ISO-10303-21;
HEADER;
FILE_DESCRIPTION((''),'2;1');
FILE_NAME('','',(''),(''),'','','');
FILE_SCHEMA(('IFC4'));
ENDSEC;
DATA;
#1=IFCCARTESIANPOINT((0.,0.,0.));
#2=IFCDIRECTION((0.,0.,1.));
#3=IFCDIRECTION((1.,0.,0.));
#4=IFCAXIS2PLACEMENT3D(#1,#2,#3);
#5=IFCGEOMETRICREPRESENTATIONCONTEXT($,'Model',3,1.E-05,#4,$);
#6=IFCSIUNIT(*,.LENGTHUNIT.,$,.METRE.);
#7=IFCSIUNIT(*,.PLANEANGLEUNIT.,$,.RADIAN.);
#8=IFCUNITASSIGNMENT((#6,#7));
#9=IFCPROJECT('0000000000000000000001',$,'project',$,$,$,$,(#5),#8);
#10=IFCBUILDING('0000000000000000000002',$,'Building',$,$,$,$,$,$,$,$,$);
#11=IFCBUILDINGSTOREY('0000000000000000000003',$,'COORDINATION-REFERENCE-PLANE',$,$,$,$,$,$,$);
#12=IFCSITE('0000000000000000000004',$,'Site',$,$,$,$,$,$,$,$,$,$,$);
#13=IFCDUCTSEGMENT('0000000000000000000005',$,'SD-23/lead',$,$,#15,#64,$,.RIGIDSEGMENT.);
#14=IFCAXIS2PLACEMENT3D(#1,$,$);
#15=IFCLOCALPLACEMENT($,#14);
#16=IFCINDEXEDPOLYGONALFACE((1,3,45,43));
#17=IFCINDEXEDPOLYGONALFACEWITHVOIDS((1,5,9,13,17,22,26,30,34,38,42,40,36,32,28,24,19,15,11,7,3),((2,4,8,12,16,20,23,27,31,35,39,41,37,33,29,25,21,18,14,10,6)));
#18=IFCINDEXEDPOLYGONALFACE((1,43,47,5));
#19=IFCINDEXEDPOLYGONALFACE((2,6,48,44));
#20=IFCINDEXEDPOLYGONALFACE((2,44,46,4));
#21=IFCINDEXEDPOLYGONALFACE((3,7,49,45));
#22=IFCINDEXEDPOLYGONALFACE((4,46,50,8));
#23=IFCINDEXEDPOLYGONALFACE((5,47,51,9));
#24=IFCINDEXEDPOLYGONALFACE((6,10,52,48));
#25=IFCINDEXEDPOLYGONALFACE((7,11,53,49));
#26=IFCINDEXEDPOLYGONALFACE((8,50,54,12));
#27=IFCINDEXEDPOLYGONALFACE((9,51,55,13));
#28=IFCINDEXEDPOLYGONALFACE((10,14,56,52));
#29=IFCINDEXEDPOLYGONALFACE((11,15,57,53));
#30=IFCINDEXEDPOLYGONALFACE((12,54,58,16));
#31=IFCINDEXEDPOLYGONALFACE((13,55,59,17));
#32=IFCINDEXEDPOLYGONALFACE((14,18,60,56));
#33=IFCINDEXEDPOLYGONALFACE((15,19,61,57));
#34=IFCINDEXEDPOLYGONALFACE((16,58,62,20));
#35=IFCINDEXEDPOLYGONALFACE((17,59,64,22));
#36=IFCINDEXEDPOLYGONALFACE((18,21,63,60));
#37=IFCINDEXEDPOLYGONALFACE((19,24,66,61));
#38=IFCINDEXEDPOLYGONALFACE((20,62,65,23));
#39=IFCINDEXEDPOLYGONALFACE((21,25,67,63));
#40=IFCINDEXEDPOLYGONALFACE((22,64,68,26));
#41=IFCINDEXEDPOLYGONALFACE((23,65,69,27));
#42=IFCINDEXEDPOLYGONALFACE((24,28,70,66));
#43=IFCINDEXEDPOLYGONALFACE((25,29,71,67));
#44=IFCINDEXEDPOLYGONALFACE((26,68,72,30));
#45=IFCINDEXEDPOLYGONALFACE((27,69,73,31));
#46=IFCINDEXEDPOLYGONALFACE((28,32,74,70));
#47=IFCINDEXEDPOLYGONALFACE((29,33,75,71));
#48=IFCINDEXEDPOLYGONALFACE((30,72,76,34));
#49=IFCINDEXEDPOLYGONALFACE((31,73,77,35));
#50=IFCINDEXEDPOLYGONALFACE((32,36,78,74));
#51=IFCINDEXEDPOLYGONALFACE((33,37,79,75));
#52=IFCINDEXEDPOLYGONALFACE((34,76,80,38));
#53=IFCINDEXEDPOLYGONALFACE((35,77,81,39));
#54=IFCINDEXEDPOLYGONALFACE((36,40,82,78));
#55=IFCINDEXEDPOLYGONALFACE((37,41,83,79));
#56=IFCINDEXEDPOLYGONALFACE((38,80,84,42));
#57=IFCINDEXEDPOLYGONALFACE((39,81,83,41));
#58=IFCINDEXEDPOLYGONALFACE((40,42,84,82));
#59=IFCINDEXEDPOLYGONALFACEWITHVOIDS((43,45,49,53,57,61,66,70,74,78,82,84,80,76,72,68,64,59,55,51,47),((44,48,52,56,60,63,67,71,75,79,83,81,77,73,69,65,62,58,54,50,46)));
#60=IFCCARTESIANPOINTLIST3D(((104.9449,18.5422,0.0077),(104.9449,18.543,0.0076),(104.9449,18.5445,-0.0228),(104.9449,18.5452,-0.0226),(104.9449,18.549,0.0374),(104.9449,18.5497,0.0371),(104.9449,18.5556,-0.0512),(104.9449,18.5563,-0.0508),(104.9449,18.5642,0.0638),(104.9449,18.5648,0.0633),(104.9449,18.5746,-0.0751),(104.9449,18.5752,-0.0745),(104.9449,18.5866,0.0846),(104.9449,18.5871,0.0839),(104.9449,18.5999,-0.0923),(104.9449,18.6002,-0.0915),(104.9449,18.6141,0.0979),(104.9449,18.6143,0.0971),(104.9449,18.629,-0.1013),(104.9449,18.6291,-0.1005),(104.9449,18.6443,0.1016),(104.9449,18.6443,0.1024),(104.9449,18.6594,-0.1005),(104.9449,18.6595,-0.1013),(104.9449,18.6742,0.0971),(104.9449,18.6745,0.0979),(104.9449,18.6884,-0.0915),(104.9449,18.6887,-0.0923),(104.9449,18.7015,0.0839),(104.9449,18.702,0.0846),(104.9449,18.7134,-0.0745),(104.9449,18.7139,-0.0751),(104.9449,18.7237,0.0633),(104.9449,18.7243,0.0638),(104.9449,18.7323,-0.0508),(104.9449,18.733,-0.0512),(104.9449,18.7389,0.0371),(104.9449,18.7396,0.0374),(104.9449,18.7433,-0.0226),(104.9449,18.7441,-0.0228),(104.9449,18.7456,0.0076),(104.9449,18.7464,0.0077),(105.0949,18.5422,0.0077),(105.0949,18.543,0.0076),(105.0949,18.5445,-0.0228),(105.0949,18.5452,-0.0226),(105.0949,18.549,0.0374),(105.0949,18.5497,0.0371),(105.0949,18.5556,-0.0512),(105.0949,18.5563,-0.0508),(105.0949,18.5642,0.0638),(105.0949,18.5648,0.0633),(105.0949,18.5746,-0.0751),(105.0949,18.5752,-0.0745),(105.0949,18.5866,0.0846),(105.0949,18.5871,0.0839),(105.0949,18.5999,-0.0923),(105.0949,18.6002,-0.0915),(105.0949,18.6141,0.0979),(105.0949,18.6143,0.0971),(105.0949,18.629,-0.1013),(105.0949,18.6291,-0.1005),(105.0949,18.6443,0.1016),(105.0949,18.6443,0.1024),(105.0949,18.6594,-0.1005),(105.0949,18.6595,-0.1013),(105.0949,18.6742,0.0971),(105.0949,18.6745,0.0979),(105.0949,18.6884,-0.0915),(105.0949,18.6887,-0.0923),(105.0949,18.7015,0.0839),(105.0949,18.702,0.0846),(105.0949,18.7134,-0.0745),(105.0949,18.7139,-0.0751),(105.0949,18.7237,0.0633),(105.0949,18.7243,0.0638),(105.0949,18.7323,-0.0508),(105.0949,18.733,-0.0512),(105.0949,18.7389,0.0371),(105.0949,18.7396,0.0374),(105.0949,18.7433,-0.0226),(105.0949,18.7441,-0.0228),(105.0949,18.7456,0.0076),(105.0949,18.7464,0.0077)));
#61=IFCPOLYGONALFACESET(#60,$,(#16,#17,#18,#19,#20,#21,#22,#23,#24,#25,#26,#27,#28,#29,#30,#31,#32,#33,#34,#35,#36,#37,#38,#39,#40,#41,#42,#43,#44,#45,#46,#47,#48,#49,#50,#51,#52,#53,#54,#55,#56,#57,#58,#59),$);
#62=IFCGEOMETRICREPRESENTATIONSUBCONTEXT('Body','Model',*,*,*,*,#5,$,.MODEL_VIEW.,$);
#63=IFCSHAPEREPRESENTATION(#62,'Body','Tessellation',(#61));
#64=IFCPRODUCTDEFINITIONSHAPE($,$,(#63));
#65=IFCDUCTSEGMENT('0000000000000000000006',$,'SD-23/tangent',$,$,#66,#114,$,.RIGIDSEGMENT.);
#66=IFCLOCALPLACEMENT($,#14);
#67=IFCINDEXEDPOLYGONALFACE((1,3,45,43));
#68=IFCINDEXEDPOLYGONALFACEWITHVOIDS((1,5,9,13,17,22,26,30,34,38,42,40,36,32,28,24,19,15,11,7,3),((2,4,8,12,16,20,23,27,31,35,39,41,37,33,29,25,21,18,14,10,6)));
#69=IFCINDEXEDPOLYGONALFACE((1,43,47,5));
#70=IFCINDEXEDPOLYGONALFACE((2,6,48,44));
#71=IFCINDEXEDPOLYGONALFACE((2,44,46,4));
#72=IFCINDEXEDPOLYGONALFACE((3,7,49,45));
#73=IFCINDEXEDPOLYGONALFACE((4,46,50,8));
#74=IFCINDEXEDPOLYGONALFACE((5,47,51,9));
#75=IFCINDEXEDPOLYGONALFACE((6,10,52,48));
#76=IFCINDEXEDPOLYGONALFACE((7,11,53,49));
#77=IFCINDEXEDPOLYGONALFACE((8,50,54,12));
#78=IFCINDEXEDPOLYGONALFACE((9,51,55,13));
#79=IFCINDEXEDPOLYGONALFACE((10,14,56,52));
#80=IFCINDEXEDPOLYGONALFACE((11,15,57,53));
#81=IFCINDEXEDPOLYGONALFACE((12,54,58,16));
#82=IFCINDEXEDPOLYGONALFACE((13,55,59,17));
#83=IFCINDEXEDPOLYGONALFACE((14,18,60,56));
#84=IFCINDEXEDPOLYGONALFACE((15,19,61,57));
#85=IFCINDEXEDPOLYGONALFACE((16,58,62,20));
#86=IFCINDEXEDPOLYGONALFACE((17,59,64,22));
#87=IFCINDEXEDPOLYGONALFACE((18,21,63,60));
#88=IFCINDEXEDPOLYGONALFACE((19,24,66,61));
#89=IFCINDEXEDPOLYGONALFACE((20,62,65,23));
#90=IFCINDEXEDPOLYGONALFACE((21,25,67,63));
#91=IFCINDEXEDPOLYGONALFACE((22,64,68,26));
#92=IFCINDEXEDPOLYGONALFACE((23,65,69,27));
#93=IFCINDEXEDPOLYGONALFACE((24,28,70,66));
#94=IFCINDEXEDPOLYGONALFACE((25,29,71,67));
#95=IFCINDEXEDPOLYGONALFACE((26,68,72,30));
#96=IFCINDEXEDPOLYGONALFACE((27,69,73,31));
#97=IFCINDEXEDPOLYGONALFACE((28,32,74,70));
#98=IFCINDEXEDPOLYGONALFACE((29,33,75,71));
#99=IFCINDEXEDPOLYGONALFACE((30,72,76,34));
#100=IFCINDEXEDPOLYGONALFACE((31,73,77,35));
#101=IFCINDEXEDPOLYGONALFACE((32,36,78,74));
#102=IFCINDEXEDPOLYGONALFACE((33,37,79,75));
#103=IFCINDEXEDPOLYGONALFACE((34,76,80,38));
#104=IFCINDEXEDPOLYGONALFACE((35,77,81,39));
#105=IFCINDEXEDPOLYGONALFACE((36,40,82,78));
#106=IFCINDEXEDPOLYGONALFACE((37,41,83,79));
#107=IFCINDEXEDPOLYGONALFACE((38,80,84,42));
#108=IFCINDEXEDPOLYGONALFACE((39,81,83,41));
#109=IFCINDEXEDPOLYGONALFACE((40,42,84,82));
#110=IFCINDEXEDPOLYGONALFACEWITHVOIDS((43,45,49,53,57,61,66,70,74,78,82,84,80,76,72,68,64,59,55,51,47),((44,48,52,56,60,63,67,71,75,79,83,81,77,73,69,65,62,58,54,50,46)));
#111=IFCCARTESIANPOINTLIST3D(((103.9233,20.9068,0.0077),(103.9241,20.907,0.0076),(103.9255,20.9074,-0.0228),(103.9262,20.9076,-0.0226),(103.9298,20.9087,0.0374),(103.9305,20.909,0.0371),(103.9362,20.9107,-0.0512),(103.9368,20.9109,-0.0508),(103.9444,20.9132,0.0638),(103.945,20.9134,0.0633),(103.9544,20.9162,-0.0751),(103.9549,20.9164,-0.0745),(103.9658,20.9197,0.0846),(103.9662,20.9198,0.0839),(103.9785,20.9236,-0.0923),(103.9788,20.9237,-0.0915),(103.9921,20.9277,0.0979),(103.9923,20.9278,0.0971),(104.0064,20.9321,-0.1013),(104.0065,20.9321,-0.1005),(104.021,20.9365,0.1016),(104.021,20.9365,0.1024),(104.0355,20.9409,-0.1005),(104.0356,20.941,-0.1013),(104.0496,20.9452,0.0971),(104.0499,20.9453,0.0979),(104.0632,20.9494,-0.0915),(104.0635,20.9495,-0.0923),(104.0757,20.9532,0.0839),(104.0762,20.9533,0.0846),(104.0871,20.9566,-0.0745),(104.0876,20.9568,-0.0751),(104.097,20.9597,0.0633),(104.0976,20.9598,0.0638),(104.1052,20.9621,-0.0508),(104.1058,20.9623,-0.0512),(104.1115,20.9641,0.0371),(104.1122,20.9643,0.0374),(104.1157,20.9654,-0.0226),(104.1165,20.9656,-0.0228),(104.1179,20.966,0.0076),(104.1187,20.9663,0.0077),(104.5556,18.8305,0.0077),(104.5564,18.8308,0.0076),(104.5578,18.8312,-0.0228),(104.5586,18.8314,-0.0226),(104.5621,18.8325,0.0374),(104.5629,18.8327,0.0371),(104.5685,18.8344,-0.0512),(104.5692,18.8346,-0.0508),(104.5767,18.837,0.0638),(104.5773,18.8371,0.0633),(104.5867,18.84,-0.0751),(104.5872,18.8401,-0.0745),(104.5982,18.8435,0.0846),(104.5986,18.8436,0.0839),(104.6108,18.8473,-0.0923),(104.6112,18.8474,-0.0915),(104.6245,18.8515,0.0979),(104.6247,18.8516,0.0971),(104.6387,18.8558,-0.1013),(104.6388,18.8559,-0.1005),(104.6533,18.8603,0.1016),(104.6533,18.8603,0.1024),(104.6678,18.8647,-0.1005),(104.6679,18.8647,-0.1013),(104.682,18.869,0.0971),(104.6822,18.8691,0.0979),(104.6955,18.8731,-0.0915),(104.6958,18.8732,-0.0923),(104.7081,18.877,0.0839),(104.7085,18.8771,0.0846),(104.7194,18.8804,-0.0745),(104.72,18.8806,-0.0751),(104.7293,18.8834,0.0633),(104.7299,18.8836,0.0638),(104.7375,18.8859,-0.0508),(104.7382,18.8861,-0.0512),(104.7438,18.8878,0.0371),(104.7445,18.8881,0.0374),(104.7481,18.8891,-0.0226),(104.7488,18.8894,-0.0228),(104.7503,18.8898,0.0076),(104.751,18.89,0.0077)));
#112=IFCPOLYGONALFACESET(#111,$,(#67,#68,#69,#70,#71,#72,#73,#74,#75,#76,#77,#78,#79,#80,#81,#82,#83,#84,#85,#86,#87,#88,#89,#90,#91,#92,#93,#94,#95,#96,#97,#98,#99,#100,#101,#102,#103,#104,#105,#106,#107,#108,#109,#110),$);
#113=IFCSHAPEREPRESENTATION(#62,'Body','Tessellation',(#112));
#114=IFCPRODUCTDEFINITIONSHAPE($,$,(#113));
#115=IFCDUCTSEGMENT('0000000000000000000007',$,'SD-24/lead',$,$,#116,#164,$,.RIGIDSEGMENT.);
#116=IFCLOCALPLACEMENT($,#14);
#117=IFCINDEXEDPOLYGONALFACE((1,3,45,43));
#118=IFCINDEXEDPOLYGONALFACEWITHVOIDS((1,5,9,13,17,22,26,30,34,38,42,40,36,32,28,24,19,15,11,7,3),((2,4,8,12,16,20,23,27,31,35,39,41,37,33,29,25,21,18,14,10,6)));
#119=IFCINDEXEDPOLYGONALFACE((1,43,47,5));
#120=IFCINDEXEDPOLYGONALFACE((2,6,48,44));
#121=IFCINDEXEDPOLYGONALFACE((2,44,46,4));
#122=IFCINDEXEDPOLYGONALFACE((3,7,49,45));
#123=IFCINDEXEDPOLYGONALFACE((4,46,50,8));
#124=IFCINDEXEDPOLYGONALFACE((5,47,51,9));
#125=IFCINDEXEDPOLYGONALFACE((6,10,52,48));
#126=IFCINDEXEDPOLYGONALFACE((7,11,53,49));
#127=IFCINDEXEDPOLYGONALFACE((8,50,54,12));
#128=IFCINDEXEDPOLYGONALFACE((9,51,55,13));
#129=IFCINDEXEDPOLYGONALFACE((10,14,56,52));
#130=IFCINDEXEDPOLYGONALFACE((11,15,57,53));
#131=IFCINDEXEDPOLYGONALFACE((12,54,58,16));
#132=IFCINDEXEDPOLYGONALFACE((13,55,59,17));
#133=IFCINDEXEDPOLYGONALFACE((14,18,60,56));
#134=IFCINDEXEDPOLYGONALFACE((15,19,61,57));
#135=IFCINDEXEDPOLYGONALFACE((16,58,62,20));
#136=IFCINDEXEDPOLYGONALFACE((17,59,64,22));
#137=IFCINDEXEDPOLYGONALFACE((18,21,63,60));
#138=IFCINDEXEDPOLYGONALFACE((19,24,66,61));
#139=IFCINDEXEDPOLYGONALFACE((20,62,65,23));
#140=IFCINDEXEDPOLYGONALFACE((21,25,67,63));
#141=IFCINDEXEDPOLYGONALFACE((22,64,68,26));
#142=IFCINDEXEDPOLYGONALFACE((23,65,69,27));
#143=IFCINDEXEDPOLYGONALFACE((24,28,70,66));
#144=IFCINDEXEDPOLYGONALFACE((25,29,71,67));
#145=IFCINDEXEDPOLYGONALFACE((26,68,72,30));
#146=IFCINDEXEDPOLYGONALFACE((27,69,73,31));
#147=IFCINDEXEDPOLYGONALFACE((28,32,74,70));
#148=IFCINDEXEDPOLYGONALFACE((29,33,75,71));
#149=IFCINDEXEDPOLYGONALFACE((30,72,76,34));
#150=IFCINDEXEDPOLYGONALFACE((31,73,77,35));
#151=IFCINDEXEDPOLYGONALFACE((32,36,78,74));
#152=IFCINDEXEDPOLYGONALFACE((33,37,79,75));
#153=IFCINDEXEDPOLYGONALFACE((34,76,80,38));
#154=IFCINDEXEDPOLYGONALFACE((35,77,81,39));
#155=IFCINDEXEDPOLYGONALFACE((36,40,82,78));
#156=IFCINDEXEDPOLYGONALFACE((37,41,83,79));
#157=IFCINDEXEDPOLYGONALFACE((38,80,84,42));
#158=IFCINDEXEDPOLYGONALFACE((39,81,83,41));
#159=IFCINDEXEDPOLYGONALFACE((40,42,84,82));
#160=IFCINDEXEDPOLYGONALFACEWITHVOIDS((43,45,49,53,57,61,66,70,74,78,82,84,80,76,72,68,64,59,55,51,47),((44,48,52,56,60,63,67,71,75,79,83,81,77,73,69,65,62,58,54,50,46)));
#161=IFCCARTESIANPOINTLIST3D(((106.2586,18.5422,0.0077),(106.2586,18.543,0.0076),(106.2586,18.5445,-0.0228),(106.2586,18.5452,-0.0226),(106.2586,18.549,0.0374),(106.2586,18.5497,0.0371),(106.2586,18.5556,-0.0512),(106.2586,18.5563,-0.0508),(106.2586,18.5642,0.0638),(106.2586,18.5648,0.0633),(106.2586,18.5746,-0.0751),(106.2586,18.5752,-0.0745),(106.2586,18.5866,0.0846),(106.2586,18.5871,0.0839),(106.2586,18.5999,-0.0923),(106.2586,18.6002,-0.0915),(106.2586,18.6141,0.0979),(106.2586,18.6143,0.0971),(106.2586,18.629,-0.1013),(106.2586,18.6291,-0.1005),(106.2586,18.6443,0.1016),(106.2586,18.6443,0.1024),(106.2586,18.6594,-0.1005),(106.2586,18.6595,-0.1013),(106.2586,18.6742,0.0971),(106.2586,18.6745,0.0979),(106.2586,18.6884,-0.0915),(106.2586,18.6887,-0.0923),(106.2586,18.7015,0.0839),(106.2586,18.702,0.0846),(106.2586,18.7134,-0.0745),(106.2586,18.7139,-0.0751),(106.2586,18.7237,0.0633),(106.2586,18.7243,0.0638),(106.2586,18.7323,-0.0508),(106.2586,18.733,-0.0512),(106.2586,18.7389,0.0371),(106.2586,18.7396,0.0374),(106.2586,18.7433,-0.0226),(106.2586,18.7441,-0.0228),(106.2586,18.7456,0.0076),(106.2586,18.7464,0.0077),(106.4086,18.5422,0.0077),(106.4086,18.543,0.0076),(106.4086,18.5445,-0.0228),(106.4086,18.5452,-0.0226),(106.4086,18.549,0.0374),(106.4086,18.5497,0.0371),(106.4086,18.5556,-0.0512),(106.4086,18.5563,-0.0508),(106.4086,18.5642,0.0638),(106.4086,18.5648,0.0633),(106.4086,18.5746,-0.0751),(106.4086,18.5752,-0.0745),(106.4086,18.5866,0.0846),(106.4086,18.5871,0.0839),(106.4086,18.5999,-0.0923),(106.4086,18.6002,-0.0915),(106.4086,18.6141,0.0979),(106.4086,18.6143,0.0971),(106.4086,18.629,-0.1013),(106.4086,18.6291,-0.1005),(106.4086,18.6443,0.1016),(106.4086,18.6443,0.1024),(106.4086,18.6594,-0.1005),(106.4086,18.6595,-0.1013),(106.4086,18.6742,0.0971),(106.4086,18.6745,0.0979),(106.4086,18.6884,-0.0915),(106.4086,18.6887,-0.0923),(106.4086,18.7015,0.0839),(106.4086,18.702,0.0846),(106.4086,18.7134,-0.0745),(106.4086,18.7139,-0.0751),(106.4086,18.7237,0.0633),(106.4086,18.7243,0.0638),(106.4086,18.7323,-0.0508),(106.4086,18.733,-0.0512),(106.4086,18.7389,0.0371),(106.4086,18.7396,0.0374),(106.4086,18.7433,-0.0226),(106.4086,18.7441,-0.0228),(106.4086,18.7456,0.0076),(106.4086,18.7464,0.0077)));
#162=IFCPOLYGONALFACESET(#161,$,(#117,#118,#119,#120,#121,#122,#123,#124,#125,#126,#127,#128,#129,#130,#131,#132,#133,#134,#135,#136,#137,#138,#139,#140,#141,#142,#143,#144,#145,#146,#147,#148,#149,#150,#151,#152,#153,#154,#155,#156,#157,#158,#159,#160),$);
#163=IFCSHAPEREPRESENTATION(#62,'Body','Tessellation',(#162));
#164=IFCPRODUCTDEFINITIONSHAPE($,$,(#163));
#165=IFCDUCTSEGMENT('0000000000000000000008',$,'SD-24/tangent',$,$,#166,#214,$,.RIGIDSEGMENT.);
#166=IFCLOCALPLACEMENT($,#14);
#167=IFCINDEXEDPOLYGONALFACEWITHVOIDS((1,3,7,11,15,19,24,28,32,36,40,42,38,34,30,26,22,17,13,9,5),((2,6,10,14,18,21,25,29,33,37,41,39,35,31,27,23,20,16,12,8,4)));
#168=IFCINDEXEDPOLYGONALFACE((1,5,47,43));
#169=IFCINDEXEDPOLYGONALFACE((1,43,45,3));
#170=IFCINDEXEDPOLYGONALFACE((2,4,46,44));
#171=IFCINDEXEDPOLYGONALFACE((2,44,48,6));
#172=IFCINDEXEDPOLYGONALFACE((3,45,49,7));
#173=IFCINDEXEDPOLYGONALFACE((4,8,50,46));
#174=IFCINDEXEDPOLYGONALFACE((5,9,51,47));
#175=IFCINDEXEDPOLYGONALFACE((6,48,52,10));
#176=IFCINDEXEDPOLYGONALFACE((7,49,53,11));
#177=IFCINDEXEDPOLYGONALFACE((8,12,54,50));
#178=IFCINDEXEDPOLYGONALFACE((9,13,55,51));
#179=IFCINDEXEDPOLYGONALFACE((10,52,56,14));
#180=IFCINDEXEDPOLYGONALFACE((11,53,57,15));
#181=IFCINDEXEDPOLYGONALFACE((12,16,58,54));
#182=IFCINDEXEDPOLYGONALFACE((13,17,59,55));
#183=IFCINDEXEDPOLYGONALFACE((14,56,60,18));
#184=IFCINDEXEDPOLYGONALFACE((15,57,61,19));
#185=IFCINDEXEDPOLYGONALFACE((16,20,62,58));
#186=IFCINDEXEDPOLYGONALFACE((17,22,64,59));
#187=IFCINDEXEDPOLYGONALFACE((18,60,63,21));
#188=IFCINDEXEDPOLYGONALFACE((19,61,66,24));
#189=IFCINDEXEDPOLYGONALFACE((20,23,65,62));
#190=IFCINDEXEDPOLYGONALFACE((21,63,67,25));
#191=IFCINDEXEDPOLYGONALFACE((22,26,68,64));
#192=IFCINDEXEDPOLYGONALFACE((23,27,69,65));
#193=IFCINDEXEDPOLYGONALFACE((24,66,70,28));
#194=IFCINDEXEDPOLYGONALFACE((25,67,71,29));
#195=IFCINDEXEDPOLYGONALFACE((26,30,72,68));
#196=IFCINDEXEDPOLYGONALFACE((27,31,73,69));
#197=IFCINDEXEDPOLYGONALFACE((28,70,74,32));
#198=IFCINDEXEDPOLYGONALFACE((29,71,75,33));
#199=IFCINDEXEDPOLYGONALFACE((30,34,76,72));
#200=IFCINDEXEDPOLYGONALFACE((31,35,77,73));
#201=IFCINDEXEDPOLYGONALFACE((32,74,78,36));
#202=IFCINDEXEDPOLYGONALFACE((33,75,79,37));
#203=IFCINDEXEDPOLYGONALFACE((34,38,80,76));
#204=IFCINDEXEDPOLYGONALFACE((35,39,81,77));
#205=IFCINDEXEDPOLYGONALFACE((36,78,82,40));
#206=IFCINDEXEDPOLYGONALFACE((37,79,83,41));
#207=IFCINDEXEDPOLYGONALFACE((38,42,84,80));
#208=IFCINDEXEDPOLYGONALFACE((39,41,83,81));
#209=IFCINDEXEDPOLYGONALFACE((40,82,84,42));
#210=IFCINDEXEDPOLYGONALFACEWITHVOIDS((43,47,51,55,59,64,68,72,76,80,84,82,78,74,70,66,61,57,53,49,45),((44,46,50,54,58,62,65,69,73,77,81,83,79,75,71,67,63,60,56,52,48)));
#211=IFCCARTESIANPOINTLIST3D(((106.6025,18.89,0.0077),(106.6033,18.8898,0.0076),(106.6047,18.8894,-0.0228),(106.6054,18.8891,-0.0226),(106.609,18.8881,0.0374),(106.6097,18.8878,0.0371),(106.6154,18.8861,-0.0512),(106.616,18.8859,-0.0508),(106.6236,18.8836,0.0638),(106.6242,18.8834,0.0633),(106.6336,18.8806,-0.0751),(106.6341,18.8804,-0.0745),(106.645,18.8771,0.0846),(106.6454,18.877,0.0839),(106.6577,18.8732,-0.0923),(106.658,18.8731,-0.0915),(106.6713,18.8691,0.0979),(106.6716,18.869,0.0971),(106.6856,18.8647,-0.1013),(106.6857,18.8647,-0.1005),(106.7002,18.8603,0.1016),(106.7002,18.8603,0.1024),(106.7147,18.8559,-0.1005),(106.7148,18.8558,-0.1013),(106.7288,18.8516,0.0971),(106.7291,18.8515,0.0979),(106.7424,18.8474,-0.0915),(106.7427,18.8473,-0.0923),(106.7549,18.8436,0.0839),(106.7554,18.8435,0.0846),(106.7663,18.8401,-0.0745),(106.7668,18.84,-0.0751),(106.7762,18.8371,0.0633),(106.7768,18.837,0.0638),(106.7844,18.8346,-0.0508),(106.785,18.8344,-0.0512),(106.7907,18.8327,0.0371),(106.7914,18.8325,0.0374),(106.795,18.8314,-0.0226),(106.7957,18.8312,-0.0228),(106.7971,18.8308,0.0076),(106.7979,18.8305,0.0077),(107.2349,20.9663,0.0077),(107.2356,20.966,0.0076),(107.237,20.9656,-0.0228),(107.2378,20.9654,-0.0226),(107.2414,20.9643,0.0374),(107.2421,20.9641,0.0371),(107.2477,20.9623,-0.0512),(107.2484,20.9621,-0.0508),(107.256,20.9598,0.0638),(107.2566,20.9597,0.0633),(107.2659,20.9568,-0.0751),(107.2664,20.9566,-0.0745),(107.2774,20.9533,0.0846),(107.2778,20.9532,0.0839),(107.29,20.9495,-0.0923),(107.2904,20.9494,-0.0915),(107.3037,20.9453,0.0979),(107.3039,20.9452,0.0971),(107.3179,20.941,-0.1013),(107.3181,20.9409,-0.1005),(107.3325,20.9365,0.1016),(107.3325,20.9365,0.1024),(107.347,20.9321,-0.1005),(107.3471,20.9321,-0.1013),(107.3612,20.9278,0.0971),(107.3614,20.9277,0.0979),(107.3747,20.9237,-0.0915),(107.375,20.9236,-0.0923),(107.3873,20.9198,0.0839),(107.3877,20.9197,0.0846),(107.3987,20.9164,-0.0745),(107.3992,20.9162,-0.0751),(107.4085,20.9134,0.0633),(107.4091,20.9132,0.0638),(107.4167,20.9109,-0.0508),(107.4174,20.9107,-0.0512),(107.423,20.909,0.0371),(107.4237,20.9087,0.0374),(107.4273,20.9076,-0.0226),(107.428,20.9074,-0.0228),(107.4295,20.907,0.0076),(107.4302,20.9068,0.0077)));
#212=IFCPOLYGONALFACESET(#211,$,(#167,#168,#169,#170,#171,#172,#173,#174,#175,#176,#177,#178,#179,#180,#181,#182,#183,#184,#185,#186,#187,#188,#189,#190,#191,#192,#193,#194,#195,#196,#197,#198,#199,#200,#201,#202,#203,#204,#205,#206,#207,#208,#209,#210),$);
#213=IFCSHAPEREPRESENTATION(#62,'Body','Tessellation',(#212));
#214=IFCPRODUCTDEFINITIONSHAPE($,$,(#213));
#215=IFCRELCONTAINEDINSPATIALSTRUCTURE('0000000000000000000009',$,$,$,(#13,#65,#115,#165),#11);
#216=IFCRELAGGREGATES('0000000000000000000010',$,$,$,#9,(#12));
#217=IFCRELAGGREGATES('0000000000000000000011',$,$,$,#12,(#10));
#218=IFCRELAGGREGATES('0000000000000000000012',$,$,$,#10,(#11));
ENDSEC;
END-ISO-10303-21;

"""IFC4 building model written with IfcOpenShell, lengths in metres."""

from ifc_helpers import new_model, si_unit, frame, origin_with_axes, place, context, subcontext, project, spatial, hollow_circle, extrude, element, save


model = new_model("IFC4")

# Units and contexts
model_context_1 = context("Model", 3, precision=1e-05, world=origin_with_axes())
body_context_1 = subcontext(model_context_1, "Body", "Model", "MODEL_VIEW")
ifc_project = project(units=[si_unit("LENGTHUNIT", "METRE"), si_unit("PLANEANGLEUNIT", "RADIAN")], contexts=[model_context_1])

# Site, building, storey
site = spatial("IfcSite", under=ifc_project, Name="Site")
building = spatial("IfcBuilding", under=site, Name="Building")
storey = spatial("IfcBuildingStorey", under=building, Name="COORDINATION-REFERENCE-PLANE")

# Duct segment
duct_segment_1_placement = place(None, frame((105.0949, 18.6443, 0.0), z_axis=(-1.0, 0.0, 0.0), x_axis=(0.0, 0.0, 1.0)))
element("IfcDuctSegment", 1, at=duct_segment_1_placement, inside=storey, Name="SD-23/lead", PredefinedType="RIGIDSEGMENT", context=body_context_1, shape_type="SweptSolid", body=[
    extrude(hollow_circle(Radius=0.1024, WallThickness=0.0008), origin_with_axes(), (0.0, 0.0, 1.0), 0.15),
])

# Duct segment
duct_segment_2_placement = place(None, frame((104.6533, 18.8603, 0.0), z_axis=(-0.291351, 0.956616, 0.0), x_axis=(0.0, 0.0, 1.0)))
element("IfcDuctSegment", 2, at=duct_segment_2_placement, inside=storey, Name="SD-23/tangent", PredefinedType="RIGIDSEGMENT", context=body_context_1, shape_type="SweptSolid", body=[
    extrude(hollow_circle(Radius=0.1024, WallThickness=0.0008), origin_with_axes(), (0.0, 0.0, 1.0), 2.1704),
])

# Duct segment
duct_segment_3_placement = place(None, frame((106.2586, 18.6443, 0.0), z_axis=(1.0, 0.0, 0.0), x_axis=(0.0, 0.0, 1.0)))
element("IfcDuctSegment", 3, at=duct_segment_3_placement, inside=storey, Name="SD-24/lead", PredefinedType="RIGIDSEGMENT", context=body_context_1, shape_type="SweptSolid", body=[
    extrude(hollow_circle(Radius=0.1024, WallThickness=0.0008), origin_with_axes(), (0.0, 0.0, 1.0), 0.15),
])

# Duct segment
duct_segment_4_placement = place(None, frame((106.7002, 18.8603, 0.0), z_axis=(0.291351, 0.956616, 0.0), x_axis=(0.0, 0.0, 1.0)))
element("IfcDuctSegment", 4, at=duct_segment_4_placement, inside=storey, Name="SD-24/tangent", PredefinedType="RIGIDSEGMENT", context=body_context_1, shape_type="SweptSolid", body=[
    extrude(hollow_circle(Radius=0.1024, WallThickness=0.0008), origin_with_axes(), (0.0, 0.0, 1.0), 2.1704),
])

save(model, "model.ifc")
